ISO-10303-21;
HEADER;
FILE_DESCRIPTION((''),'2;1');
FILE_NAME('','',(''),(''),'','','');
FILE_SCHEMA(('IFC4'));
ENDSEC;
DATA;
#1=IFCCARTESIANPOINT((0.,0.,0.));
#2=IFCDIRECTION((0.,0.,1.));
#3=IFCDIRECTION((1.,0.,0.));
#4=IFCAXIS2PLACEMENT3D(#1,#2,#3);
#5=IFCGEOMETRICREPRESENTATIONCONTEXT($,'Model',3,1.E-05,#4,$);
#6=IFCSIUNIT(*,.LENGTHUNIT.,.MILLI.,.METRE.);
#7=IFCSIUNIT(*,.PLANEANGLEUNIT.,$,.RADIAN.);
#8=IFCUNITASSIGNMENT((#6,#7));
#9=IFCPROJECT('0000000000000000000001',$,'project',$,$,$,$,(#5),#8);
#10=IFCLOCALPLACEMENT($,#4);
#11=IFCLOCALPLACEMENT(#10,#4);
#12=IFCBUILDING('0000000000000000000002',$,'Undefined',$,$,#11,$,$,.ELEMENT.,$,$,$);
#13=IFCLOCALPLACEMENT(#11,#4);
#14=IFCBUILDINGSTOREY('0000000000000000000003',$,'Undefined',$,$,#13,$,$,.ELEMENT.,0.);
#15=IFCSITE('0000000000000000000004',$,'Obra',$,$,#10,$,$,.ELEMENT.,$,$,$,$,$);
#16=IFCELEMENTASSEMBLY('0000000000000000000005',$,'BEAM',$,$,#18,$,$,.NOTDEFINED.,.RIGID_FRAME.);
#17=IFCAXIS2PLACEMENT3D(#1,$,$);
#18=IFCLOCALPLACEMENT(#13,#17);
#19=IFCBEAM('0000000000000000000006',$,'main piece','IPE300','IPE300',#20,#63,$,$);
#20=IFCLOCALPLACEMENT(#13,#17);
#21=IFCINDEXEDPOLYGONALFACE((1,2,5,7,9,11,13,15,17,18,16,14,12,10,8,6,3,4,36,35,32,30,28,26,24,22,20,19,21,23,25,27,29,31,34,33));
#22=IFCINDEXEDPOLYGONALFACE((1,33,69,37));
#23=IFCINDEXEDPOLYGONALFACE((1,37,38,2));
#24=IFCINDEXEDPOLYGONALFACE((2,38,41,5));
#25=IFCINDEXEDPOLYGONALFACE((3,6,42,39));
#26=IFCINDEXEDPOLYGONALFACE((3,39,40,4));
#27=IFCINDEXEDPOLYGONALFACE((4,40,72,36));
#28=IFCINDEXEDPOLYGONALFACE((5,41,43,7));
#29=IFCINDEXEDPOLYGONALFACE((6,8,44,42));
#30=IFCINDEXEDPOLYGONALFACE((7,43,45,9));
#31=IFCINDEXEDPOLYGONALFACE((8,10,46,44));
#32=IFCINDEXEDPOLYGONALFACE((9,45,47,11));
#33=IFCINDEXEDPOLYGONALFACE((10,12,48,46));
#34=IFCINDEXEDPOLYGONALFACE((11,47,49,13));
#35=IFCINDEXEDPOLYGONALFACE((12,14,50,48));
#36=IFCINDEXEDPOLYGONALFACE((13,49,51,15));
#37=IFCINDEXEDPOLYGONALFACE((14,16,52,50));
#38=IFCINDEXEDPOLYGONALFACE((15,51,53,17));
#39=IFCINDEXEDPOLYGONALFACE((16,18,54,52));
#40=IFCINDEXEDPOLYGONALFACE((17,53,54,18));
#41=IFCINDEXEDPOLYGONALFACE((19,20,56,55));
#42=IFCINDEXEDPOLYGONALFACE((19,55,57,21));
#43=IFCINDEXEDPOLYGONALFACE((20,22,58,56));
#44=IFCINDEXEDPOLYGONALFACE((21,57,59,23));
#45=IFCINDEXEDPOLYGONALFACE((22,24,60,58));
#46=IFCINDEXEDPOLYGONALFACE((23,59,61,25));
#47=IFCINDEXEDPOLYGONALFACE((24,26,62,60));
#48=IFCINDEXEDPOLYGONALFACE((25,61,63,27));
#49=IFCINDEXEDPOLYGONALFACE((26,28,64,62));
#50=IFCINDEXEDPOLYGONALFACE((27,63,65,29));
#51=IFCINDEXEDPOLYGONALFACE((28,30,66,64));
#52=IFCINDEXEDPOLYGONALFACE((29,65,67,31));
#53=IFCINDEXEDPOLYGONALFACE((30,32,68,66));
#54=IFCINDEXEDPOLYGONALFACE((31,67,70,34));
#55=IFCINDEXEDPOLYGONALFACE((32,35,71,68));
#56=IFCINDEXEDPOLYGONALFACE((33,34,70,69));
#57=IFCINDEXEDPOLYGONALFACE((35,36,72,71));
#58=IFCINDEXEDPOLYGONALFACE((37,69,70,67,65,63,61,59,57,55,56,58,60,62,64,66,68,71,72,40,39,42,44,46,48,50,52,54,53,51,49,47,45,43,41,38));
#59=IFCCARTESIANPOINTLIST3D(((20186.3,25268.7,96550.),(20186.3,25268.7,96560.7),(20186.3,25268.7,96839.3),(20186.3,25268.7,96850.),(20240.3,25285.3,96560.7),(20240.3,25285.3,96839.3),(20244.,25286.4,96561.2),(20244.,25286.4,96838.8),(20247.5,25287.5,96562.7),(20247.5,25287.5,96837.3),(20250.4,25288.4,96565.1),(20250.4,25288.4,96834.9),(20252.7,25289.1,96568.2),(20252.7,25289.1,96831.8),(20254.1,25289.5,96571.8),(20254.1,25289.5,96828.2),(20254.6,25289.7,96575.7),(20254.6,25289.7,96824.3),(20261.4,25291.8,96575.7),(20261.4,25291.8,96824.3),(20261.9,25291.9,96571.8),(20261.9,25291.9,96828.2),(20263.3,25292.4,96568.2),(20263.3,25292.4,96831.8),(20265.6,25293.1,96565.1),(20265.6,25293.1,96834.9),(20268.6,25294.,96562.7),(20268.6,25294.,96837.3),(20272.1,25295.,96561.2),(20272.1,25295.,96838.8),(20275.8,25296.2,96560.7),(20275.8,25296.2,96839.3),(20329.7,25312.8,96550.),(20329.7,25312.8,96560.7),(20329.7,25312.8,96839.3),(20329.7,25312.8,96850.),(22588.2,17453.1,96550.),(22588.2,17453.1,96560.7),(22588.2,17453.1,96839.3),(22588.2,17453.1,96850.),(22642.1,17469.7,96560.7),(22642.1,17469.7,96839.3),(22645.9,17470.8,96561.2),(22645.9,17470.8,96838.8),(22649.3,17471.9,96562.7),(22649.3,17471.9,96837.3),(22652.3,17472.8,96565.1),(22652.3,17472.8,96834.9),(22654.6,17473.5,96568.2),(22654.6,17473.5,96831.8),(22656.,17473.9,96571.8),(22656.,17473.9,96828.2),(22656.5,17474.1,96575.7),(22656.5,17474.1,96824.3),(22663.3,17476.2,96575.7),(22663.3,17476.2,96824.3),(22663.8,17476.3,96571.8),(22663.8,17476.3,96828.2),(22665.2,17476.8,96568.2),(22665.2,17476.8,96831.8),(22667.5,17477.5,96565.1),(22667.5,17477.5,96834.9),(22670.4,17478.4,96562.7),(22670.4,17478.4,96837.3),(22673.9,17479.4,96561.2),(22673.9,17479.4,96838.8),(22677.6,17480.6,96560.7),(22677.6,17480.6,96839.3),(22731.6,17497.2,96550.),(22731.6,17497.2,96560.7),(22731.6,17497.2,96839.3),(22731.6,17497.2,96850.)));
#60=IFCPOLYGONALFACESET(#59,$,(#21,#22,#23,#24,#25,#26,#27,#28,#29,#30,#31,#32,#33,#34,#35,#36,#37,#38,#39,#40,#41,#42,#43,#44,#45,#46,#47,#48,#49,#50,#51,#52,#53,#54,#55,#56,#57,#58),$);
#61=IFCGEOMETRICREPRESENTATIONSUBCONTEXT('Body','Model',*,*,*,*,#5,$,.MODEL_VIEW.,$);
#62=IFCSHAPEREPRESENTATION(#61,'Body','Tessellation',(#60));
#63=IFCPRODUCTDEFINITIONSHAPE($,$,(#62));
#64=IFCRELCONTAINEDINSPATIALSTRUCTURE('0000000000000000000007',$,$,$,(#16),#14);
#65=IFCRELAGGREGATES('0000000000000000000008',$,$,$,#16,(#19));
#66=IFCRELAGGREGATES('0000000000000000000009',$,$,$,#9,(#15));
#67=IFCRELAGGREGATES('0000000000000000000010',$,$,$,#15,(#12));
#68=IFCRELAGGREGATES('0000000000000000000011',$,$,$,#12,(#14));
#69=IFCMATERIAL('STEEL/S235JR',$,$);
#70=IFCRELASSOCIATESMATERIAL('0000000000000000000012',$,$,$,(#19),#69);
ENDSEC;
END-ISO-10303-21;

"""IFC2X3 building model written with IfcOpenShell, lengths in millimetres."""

from ifc_helpers import new_model, si_unit, frame, origin_with_axes, origin_2d_with_axis, place, context, subcontext, project, spatial, i_section, extrude, material, element, aggregate, save


model = new_model("IFC2X3")

# Units and contexts
model_context = context("Model", 3, precision=1e-05, world=origin_with_axes())
body_context = subcontext(model_context, "Body", "Model", "MODEL_VIEW")
ifc_project = project(units=[si_unit("LENGTHUNIT", "METRE", prefix="MILLI"), si_unit("PLANEANGLEUNIT", "RADIAN")], contexts=[model_context])

# Site, building, storey
site_placement = place(None, origin_with_axes())
site = spatial("IfcSite", under=ifc_project, at=site_placement, Name="Obra", CompositionType="ELEMENT")
building_placement = place(site_placement, origin_with_axes())
building = spatial("IfcBuilding", under=site, at=building_placement, Name="Undefined", CompositionType="ELEMENT")
storey_placement = place(building_placement, origin_with_axes())
storey = spatial("IfcBuildingStorey", under=building, at=storey_placement, Name="Undefined", CompositionType="ELEMENT", Elevation=0.0)

# Shared definitions
ifc_material = material(Name="STEEL/S235JR")

# Element assembly, beam
assembly_1_placement = place(storey_placement, origin_with_axes())
assembly_1 = element("IfcElementAssembly", 1, at=assembly_1_placement, inside=storey, Name="BEAM", AssemblyPlace="NOTDEFINED", PredefinedType="RIGID_FRAME")
beam_1_placement = place(assembly_1_placement, frame((22659.9, 17475.1, 96700.0), z_axis=(0.0, 0.0, 1.0), x_axis=(-0.293756, 0.955881, 0.0)))
beam_1 = element("IfcBeam", 2, at=beam_1_placement, material=ifc_material, Name="main piece", Description="IPE300", ObjectType="IPE300", context=body_context, shape_type="SweptSolid", body=[
    extrude(i_section(OverallWidth=150.0, OverallDepth=300.0, WebThickness=7.1, FlangeThickness=10.7, FilletRadius=15.0, at=origin_2d_with_axis()), frame((8176.3, 0.0, 0.0), z_axis=(-1.0, 0.0, 0.0), x_axis=(0.0, -1.0, 0.0)), (0.0, 0.0, 1.0), 8176.3),
])
aggregate(assembly_1, [beam_1])

save(model, "model.ifc")
